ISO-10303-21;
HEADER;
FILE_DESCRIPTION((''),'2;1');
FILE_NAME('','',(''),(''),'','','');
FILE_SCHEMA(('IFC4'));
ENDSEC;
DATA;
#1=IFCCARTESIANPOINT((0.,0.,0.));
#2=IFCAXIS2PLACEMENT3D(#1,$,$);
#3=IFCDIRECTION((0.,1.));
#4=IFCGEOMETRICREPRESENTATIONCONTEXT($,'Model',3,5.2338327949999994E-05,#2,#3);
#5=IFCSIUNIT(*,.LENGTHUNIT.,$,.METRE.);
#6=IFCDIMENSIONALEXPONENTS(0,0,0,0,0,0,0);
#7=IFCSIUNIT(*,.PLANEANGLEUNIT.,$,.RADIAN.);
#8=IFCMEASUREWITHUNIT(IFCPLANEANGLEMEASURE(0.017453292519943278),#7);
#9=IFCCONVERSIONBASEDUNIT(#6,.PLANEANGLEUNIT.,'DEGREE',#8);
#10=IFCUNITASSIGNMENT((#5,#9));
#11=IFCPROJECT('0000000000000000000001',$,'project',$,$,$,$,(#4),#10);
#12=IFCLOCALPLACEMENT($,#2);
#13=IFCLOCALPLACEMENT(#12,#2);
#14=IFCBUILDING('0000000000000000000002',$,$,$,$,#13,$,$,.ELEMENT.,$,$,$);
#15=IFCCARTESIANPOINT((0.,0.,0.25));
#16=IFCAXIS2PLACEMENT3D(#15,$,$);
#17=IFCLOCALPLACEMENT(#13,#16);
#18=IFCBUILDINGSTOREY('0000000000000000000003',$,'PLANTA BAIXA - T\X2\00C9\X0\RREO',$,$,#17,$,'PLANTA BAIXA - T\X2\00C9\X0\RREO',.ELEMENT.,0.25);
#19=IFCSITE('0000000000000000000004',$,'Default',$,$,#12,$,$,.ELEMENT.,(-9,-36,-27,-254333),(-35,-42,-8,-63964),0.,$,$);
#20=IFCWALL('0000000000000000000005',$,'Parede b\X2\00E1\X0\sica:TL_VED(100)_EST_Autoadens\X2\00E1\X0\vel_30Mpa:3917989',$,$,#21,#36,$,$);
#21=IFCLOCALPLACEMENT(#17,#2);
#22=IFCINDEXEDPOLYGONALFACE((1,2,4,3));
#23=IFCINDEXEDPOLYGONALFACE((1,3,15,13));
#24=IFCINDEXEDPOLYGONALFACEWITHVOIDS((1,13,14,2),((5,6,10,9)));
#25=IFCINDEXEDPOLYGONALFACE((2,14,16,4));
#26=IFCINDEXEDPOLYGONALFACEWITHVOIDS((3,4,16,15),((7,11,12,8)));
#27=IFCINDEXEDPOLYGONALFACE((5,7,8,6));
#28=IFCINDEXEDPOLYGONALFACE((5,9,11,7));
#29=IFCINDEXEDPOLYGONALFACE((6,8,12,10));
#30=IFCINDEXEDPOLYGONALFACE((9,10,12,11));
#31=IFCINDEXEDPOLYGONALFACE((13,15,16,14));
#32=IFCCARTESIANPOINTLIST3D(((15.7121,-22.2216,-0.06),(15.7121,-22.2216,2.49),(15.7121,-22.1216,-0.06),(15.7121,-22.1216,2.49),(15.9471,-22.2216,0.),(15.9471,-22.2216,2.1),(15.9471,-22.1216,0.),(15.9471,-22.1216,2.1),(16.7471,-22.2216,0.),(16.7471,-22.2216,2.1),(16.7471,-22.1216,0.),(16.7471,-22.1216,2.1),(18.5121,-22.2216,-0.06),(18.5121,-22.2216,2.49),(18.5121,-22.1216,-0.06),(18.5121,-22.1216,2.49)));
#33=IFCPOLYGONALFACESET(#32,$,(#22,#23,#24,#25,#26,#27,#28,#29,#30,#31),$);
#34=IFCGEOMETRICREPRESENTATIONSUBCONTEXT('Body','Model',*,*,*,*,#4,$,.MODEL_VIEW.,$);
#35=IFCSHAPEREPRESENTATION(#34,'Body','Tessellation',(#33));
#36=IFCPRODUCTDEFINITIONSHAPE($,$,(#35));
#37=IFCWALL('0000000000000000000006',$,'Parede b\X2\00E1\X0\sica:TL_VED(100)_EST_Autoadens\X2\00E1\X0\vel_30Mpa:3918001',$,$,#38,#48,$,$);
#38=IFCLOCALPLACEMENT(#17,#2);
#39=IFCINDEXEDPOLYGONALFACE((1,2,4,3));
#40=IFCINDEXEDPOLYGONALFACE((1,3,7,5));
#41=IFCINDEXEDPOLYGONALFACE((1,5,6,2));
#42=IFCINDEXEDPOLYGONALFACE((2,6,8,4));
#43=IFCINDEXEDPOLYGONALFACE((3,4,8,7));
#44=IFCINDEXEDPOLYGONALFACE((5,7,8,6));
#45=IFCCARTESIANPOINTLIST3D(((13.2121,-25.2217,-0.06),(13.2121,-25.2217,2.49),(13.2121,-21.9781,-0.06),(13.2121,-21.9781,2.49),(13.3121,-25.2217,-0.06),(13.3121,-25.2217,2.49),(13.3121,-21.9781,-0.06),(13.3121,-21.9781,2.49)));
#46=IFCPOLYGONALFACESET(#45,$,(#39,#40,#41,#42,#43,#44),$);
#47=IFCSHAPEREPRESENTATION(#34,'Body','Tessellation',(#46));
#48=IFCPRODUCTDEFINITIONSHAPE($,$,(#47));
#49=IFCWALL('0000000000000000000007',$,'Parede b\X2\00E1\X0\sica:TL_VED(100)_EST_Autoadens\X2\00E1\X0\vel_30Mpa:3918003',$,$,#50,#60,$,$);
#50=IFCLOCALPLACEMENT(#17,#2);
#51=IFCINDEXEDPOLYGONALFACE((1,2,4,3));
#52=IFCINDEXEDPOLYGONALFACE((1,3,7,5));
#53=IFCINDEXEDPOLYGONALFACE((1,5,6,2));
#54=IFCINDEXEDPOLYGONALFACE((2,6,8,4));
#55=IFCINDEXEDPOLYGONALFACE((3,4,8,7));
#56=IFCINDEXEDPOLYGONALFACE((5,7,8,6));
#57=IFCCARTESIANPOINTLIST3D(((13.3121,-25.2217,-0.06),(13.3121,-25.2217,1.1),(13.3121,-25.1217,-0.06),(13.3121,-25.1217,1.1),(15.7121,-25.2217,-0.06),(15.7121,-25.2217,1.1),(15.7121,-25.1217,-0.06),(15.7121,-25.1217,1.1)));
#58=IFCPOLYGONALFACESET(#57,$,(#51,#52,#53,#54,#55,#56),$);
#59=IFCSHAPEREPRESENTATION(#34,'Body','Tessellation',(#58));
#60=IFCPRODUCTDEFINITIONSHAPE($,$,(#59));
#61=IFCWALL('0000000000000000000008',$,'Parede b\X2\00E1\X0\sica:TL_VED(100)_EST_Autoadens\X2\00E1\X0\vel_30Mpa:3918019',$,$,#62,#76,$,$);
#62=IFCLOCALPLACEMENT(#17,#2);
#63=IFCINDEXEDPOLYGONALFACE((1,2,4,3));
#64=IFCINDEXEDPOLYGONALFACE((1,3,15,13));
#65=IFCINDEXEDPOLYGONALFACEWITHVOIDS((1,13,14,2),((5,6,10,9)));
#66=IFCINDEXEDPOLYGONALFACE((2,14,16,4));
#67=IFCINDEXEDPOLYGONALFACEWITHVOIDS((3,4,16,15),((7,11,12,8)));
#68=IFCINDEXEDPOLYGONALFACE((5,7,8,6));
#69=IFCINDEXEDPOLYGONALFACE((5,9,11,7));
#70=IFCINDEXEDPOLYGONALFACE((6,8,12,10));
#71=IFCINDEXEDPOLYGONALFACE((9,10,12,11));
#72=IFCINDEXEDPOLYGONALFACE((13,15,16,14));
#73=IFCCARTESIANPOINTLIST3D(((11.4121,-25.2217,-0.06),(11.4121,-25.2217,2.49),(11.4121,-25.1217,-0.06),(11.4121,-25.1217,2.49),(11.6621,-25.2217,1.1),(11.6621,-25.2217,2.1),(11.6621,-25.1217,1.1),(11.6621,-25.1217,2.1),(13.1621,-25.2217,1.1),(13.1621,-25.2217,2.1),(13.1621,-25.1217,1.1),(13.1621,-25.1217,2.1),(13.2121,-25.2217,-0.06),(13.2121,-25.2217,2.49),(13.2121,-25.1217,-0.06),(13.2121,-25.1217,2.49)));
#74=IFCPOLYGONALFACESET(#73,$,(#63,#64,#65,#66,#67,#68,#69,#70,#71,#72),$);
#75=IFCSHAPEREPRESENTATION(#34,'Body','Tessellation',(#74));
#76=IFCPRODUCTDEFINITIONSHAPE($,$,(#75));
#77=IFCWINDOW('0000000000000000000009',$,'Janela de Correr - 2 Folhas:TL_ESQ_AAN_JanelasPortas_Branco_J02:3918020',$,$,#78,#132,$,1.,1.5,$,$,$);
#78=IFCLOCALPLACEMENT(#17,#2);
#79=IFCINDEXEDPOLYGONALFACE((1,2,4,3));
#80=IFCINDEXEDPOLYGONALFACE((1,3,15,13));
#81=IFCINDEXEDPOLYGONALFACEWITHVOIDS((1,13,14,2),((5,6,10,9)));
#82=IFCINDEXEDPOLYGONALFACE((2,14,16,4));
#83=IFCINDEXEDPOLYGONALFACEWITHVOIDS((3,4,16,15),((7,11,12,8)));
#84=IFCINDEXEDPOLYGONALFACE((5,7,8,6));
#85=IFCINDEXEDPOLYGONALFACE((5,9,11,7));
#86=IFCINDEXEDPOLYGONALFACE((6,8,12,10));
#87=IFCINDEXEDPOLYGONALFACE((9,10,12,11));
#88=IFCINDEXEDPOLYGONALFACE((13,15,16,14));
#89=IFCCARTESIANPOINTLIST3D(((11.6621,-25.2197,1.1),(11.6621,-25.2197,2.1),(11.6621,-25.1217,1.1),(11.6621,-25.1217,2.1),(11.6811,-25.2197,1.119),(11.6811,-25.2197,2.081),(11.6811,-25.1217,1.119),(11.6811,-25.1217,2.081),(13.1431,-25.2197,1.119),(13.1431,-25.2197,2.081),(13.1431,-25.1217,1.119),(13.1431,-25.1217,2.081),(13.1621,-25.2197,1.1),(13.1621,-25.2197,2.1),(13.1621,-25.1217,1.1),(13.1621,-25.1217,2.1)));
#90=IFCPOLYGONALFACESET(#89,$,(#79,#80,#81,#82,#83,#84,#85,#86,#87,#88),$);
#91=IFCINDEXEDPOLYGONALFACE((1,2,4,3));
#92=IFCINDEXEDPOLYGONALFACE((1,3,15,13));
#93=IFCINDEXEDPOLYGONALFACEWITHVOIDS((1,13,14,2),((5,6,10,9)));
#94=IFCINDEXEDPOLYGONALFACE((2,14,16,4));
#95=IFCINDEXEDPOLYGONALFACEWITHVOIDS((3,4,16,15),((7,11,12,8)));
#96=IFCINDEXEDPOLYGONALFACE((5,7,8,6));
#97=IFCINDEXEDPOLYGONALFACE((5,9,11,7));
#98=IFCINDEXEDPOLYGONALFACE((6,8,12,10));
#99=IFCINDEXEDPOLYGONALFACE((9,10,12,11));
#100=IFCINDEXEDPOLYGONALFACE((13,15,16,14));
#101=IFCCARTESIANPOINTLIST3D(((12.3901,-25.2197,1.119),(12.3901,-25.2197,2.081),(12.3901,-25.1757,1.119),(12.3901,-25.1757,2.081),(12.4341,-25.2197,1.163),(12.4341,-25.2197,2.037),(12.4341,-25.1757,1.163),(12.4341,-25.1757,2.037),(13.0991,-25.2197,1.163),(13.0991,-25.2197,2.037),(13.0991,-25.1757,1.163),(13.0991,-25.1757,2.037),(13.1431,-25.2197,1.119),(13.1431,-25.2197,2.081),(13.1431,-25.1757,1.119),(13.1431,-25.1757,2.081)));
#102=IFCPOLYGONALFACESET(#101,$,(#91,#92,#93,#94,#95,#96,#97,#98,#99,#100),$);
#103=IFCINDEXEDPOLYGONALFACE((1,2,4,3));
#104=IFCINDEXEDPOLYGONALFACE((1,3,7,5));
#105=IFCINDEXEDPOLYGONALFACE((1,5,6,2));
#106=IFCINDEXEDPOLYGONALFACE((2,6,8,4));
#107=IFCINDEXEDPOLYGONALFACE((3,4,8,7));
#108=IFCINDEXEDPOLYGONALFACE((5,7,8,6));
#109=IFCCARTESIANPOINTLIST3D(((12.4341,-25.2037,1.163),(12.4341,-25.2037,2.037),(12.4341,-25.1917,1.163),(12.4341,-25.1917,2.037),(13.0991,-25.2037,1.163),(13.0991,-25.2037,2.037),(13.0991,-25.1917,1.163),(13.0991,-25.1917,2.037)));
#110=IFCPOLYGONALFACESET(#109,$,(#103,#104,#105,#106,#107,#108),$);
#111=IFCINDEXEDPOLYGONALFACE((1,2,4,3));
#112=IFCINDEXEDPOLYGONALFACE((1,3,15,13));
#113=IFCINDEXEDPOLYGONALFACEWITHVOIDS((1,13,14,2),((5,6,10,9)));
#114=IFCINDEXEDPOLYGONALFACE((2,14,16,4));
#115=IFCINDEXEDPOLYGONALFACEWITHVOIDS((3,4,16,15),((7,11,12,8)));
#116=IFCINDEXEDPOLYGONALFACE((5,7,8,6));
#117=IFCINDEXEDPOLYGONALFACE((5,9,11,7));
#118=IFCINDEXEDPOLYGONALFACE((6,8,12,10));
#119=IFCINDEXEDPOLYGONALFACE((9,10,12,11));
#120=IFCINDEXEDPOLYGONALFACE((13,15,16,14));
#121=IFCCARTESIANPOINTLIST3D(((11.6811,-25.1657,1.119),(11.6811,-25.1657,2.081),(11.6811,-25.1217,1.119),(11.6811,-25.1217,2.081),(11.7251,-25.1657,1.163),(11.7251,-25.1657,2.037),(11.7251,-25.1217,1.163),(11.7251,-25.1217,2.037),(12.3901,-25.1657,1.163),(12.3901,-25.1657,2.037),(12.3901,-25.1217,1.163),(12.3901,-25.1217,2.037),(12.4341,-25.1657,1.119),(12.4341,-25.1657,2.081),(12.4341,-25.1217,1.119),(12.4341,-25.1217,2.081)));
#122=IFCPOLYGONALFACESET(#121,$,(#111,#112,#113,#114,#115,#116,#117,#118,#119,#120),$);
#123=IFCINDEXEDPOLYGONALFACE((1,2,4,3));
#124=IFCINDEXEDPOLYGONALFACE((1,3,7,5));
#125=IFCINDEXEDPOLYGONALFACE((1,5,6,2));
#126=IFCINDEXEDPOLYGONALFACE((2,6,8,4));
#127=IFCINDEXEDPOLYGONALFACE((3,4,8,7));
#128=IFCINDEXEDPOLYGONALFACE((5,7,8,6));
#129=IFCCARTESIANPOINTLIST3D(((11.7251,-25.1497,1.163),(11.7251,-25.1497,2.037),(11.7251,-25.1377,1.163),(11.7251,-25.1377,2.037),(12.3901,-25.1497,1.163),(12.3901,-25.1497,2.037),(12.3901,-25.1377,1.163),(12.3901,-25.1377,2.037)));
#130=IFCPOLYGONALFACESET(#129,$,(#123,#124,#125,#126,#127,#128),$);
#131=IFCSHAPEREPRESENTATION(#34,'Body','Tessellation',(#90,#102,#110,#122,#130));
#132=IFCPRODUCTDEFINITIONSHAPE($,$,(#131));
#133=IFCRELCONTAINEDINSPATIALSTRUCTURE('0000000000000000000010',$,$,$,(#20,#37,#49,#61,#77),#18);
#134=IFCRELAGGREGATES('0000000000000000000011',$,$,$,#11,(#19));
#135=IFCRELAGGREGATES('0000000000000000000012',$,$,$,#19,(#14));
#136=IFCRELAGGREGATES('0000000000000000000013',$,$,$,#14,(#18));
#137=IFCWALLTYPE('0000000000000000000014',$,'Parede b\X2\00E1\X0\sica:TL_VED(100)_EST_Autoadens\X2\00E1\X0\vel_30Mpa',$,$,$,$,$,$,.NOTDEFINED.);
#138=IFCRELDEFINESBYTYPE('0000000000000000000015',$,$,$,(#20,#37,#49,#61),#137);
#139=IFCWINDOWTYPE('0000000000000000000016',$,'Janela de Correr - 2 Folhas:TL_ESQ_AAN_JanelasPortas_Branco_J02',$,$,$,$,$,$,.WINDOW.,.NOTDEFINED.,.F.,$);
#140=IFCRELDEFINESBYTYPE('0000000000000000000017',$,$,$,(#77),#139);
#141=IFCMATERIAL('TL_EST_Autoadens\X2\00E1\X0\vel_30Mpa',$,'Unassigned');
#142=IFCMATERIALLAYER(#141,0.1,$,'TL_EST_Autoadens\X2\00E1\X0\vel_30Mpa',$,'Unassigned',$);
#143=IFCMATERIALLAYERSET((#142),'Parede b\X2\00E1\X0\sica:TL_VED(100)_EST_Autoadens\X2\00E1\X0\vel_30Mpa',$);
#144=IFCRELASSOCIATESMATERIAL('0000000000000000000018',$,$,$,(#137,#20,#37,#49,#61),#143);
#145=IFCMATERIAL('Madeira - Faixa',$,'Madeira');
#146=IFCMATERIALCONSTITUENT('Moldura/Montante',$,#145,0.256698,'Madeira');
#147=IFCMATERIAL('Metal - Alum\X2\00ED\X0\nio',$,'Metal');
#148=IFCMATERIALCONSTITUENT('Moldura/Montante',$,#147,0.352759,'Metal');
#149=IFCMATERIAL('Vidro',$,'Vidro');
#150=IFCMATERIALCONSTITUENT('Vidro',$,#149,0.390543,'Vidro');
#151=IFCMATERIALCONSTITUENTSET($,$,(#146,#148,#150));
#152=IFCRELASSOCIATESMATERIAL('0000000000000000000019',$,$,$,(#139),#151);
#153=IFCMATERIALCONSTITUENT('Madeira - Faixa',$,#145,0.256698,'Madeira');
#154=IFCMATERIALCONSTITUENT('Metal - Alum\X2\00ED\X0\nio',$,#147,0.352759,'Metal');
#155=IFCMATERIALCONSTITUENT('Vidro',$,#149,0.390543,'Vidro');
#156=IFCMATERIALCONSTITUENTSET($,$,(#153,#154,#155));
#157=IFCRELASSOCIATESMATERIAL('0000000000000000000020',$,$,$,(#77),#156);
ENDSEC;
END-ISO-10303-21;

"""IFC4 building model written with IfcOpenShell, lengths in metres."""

from ifc_helpers import new_model, entity, si_unit, converted_unit, direction, frame, frame_2d, origin, origin_2d_with_axis, place, context, subcontext, project, spatial, polyline, rectangle, outline, extrude, source, transform, mapped, material, layer, layer_set, layer_usage, constituent, constituent_set, type_object, type_shapes, element, fill, save


model = new_model("IFC4")

# Units and contexts
model_context = context("Model", 3, precision=5.2338327949999994e-05, world=origin(), true_north=direction((0.0, 1.0)))
body_context = subcontext(model_context, "Body", "Model", "MODEL_VIEW")
ifc_project = project(units=[si_unit("LENGTHUNIT", "METRE"), converted_unit("PLANEANGLEUNIT", "DEGREE", entity("IfcPlaneAngleMeasure", 0.017453292519943278), si_unit("PLANEANGLEUNIT", "RADIAN"), dimensions=[0, 0, 0, 0, 0, 0, 0])], contexts=[model_context])

# Site, building, storey
site_placement = place(None, frame((0.0, 0.0, 0.0)))
site = spatial("IfcSite", under=ifc_project, at=site_placement, Name="Default", CompositionType="ELEMENT", RefLatitude=(-9, -36, -27, -254333), RefLongitude=(-35, -42, -8, -63964), RefElevation=0.0)
building_placement = place(site_placement, origin())
building = spatial("IfcBuilding", under=site, at=building_placement, CompositionType="ELEMENT")
storey_placement = place(building_placement, frame((0.0, 0.0, 0.25)))
storey = spatial("IfcBuildingStorey", under=building, at=storey_placement, Name="PLANTA BAIXA - TÉRREO", LongName="PLANTA BAIXA - TÉRREO", CompositionType="ELEMENT", Elevation=0.25)

# Wall, opening
ifc_material_1 = material(Name="TL_EST_Autoadensável_30Mpa", Category="Unassigned")
ifc_layer_1 = layer(ifc_material_1, 0.1, Name="TL_EST_Autoadensável_30Mpa", Category="Unassigned")
ifc_layer_set_1 = layer_set([ifc_layer_1], Name="Parede básica:TL_VED(100)_EST_Autoadensável_30Mpa")
ifc_layer_usage_1 = layer_usage(ifc_layer_set_1, "AXIS2", "POSITIVE", -0.05)
wall_type_1 = type_object("IfcWallType", Name="Parede básica:TL_VED(100)_EST_Autoadensável_30Mpa", PredefinedType="NOTDEFINED", material=ifc_layer_set_1)
wall_1_placement = place(storey_placement, frame((15.7121, -22.1716, -0.06)))
wall_1 = element("IfcWall", 1, at=wall_1_placement, inside=storey, type_object=wall_type_1, material=ifc_layer_usage_1, Name="Parede básica:TL_VED(100)_EST_Autoadensável_30Mpa:3917989", context=body_context, shape_type="SweptSolid", body=[
    extrude(rectangle(XDim=2.8, YDim=0.1, at=frame_2d((1.4, 0.0), x_axis=(-1.0, 0.0))), origin(), (0.0, 0.0, 1.0), 2.55),
])
opening_1_placement = place(wall_1_placement, frame((1.035, 0.05, 0.06)))
element("IfcOpeningElement", 2, at=opening_1_placement, cuts=wall_1, PredefinedType="OPENING", context=body_context, shape_type="SweptSolid", body=[
    extrude(rectangle(XDim=2.1, YDim=0.8, at=frame_2d((1.05, 0.4), x_axis=(1.0, 0.0))), frame((0.0, 0.0, 0.0), z_axis=(0.0, -1.0, 0.0), x_axis=(0.0, 0.0, 1.0)), (0.0, 0.0, 1.0), 0.1),
])

# Walls
ifc_layer_usage_2 = layer_usage(ifc_layer_set_1, "AXIS2", "NEGATIVE", 0.05)
wall_2_placement = place(storey_placement, frame((13.2621, -25.2217, -0.06), z_axis=(0.0, 0.0, 1.0), x_axis=(0.0, 1.0, 0.0)))
element("IfcWall", 3, at=wall_2_placement, inside=storey, type_object=wall_type_1, material=ifc_layer_usage_2, Name="Parede básica:TL_VED(100)_EST_Autoadensável_30Mpa:3918001", context=body_context, shape_type="SweptSolid", body=[
    extrude(rectangle(XDim=3.2437, YDim=0.1, at=frame_2d((1.6218, 0.0), x_axis=(-1.0, 0.0))), origin(), (0.0, 0.0, 1.0), 2.55),
])
ifc_layer_usage_3 = layer_usage(ifc_layer_set_1, "AXIS2", "NEGATIVE", 0.05)
wall_3_placement = place(storey_placement, frame((15.7121, -25.1717, -0.06), z_axis=(0.0, 0.0, 1.0), x_axis=(-1.0, 0.0, 0.0)))
element("IfcWall", 4, at=wall_3_placement, inside=storey, type_object=wall_type_1, material=ifc_layer_usage_3, Name="Parede básica:TL_VED(100)_EST_Autoadensável_30Mpa:3918003", context=body_context, shape_type="SweptSolid", body=[
    extrude(rectangle(XDim=2.4, YDim=0.1, at=frame_2d((1.2, 0.0), x_axis=(-1.0, 0.0))), origin(), (0.0, 0.0, 1.0), 1.16),
])

# Wall, opening, window
ifc_layer_usage_4 = layer_usage(ifc_layer_set_1, "AXIS2", "NEGATIVE", 0.05)
wall_4_placement = place(storey_placement, frame((13.2121, -25.1717, -0.06), z_axis=(0.0, 0.0, 1.0), x_axis=(-1.0, 0.0, 0.0)))
wall_4 = element("IfcWall", 5, at=wall_4_placement, inside=storey, type_object=wall_type_1, material=ifc_layer_usage_4, Name="Parede básica:TL_VED(100)_EST_Autoadensável_30Mpa:3918019", context=body_context, shape_type="SweptSolid", body=[
    extrude(rectangle(XDim=1.8, YDim=0.1, at=frame_2d((0.9, 0.0), x_axis=(-1.0, 0.0))), origin(), (0.0, 0.0, 1.0), 2.55),
])
opening_2_placement = place(wall_4_placement, frame((0.05, -0.05, 1.16)))
opening_2 = element("IfcOpeningElement", 6, at=opening_2_placement, cuts=wall_4, PredefinedType="OPENING", context=body_context, shape_type="SweptSolid", body=[
    extrude(rectangle(XDim=1.0, YDim=1.5, at=frame_2d((0.5, 0.75), x_axis=(-1.0, 0.0))), frame((0.0, 0.0, 0.0), z_axis=(0.0, 1.0, 0.0), x_axis=(0.0, 0.0, 1.0)), (0.0, 0.0, 1.0), 0.1),
])
ifc_material_2 = material(Name="Madeira - Faixa", Category="Madeira")
ifc_constituent_1 = constituent(ifc_material_2, Name="Madeira - Faixa", Category="Madeira", fraction=0.256698)
ifc_material_3 = material(Name="Metal - Alumínio", Category="Metal")
ifc_constituent_2 = constituent(ifc_material_3, Name="Metal - Alumínio", Category="Metal", fraction=0.352759)
ifc_material_4 = material(Name="Vidro", Category="Vidro")
ifc_constituent_3 = constituent(ifc_material_4, Name="Vidro", Category="Vidro", fraction=0.390543)
ifc_constituent_set_1 = constituent_set(constituents=[ifc_constituent_1, ifc_constituent_2, ifc_constituent_3])
ifc_constituent_4 = constituent(ifc_material_2, Name="Moldura/Montante", Category="Madeira", fraction=0.256698)
ifc_constituent_5 = constituent(ifc_material_3, Name="Moldura/Montante", Category="Metal", fraction=0.352759)
ifc_constituent_6 = constituent(ifc_material_4, Name="Vidro", Category="Vidro", fraction=0.390543)
ifc_constituent_set_2 = constituent_set(constituents=[ifc_constituent_4, ifc_constituent_5, ifc_constituent_6])
window_type = type_object("IfcWindowType", Name="Janela de Correr - 2 Folhas:TL_ESQ_AAN_JanelasPortas_Branco_J02", ParameterTakesPrecedence=False, PartitioningType="NOTDEFINED", PredefinedType="WINDOW", material=ifc_constituent_set_2)
shared_shape_1 = source(origin(), body_context, "Body", "SweptSolid", [
    extrude(outline(polyline([(-0.75, -0.5), (0.75, -0.5), (0.75, 0.5), (-0.75, 0.5), (-0.75, -0.5)]), holes=[polyline([(-0.731, -0.481), (-0.731, 0.481), (0.731, 0.481), (0.731, -0.481), (-0.731, -0.481)])]), frame((0.75, 0.124, 0.5), z_axis=(0.0, -1.0, 0.0), x_axis=(-1.0, 0.0, 0.0)), (0.0, 0.0, 1.0), 0.098),
    extrude(outline(polyline([(-0.3765, -0.481), (0.3765, -0.481), (0.3765, 0.481), (-0.3765, 0.481), (-0.3765, -0.481)]), holes=[polyline([(-0.3325, -0.437), (-0.3325, 0.437), (0.3325, 0.437), (0.3325, -0.437), (-0.3325, -0.437)])]), frame((0.3955, 0.124, 0.5), z_axis=(0.0, -1.0, 0.0), x_axis=(-1.0, 0.0, 0.0)), (0.0, 0.0, 1.0), 0.044),
    extrude(rectangle(XDim=0.665, YDim=0.012, at=origin_2d_with_axis()), frame((0.3955, 0.102, 0.063), z_axis=(0.0, 0.0, 1.0), x_axis=(-1.0, 0.0, 0.0)), (0.0, 0.0, 1.0), 0.874),
    extrude(outline(polyline([(-0.481, -0.3765), (0.481, -0.3765), (0.481, 0.3765), (-0.481, 0.3765), (-0.481, -0.3765)]), holes=[polyline([(-0.437, -0.3325), (-0.437, 0.3325), (0.437, 0.3325), (0.437, -0.3325), (-0.437, -0.3325)])]), frame((1.1045, 0.07, 0.5), z_axis=(0.0, -1.0, 0.0), x_axis=(0.0, 0.0, -1.0)), (0.0, 0.0, 1.0), 0.044),
    extrude(rectangle(XDim=0.665, YDim=0.012, at=origin_2d_with_axis()), frame((1.1045, 0.048, 0.063), z_axis=(0.0, 0.0, 1.0), x_axis=(-1.0, 0.0, 0.0)), (0.0, 0.0, 1.0), 0.874),
])
type_shapes(window_type, [shared_shape_1])
window_placement = place(opening_2_placement, frame((0.0, -0.026, 0.0)))
window = element("IfcWindow", 7, at=window_placement, inside=storey, type_object=window_type, material=ifc_constituent_set_1, Name="Janela de Correr - 2 Folhas:TL_ESQ_AAN_JanelasPortas_Branco_J02:3918020", OverallHeight=1.0, OverallWidth=1.5, context=body_context, shape_type="MappedRepresentation", body=[
    mapped(shared_shape_1, transform((0.0, 0.0, 0.0), scale=1.0)),
])
fill(opening_2, window)

save(model, "model.ifc")
